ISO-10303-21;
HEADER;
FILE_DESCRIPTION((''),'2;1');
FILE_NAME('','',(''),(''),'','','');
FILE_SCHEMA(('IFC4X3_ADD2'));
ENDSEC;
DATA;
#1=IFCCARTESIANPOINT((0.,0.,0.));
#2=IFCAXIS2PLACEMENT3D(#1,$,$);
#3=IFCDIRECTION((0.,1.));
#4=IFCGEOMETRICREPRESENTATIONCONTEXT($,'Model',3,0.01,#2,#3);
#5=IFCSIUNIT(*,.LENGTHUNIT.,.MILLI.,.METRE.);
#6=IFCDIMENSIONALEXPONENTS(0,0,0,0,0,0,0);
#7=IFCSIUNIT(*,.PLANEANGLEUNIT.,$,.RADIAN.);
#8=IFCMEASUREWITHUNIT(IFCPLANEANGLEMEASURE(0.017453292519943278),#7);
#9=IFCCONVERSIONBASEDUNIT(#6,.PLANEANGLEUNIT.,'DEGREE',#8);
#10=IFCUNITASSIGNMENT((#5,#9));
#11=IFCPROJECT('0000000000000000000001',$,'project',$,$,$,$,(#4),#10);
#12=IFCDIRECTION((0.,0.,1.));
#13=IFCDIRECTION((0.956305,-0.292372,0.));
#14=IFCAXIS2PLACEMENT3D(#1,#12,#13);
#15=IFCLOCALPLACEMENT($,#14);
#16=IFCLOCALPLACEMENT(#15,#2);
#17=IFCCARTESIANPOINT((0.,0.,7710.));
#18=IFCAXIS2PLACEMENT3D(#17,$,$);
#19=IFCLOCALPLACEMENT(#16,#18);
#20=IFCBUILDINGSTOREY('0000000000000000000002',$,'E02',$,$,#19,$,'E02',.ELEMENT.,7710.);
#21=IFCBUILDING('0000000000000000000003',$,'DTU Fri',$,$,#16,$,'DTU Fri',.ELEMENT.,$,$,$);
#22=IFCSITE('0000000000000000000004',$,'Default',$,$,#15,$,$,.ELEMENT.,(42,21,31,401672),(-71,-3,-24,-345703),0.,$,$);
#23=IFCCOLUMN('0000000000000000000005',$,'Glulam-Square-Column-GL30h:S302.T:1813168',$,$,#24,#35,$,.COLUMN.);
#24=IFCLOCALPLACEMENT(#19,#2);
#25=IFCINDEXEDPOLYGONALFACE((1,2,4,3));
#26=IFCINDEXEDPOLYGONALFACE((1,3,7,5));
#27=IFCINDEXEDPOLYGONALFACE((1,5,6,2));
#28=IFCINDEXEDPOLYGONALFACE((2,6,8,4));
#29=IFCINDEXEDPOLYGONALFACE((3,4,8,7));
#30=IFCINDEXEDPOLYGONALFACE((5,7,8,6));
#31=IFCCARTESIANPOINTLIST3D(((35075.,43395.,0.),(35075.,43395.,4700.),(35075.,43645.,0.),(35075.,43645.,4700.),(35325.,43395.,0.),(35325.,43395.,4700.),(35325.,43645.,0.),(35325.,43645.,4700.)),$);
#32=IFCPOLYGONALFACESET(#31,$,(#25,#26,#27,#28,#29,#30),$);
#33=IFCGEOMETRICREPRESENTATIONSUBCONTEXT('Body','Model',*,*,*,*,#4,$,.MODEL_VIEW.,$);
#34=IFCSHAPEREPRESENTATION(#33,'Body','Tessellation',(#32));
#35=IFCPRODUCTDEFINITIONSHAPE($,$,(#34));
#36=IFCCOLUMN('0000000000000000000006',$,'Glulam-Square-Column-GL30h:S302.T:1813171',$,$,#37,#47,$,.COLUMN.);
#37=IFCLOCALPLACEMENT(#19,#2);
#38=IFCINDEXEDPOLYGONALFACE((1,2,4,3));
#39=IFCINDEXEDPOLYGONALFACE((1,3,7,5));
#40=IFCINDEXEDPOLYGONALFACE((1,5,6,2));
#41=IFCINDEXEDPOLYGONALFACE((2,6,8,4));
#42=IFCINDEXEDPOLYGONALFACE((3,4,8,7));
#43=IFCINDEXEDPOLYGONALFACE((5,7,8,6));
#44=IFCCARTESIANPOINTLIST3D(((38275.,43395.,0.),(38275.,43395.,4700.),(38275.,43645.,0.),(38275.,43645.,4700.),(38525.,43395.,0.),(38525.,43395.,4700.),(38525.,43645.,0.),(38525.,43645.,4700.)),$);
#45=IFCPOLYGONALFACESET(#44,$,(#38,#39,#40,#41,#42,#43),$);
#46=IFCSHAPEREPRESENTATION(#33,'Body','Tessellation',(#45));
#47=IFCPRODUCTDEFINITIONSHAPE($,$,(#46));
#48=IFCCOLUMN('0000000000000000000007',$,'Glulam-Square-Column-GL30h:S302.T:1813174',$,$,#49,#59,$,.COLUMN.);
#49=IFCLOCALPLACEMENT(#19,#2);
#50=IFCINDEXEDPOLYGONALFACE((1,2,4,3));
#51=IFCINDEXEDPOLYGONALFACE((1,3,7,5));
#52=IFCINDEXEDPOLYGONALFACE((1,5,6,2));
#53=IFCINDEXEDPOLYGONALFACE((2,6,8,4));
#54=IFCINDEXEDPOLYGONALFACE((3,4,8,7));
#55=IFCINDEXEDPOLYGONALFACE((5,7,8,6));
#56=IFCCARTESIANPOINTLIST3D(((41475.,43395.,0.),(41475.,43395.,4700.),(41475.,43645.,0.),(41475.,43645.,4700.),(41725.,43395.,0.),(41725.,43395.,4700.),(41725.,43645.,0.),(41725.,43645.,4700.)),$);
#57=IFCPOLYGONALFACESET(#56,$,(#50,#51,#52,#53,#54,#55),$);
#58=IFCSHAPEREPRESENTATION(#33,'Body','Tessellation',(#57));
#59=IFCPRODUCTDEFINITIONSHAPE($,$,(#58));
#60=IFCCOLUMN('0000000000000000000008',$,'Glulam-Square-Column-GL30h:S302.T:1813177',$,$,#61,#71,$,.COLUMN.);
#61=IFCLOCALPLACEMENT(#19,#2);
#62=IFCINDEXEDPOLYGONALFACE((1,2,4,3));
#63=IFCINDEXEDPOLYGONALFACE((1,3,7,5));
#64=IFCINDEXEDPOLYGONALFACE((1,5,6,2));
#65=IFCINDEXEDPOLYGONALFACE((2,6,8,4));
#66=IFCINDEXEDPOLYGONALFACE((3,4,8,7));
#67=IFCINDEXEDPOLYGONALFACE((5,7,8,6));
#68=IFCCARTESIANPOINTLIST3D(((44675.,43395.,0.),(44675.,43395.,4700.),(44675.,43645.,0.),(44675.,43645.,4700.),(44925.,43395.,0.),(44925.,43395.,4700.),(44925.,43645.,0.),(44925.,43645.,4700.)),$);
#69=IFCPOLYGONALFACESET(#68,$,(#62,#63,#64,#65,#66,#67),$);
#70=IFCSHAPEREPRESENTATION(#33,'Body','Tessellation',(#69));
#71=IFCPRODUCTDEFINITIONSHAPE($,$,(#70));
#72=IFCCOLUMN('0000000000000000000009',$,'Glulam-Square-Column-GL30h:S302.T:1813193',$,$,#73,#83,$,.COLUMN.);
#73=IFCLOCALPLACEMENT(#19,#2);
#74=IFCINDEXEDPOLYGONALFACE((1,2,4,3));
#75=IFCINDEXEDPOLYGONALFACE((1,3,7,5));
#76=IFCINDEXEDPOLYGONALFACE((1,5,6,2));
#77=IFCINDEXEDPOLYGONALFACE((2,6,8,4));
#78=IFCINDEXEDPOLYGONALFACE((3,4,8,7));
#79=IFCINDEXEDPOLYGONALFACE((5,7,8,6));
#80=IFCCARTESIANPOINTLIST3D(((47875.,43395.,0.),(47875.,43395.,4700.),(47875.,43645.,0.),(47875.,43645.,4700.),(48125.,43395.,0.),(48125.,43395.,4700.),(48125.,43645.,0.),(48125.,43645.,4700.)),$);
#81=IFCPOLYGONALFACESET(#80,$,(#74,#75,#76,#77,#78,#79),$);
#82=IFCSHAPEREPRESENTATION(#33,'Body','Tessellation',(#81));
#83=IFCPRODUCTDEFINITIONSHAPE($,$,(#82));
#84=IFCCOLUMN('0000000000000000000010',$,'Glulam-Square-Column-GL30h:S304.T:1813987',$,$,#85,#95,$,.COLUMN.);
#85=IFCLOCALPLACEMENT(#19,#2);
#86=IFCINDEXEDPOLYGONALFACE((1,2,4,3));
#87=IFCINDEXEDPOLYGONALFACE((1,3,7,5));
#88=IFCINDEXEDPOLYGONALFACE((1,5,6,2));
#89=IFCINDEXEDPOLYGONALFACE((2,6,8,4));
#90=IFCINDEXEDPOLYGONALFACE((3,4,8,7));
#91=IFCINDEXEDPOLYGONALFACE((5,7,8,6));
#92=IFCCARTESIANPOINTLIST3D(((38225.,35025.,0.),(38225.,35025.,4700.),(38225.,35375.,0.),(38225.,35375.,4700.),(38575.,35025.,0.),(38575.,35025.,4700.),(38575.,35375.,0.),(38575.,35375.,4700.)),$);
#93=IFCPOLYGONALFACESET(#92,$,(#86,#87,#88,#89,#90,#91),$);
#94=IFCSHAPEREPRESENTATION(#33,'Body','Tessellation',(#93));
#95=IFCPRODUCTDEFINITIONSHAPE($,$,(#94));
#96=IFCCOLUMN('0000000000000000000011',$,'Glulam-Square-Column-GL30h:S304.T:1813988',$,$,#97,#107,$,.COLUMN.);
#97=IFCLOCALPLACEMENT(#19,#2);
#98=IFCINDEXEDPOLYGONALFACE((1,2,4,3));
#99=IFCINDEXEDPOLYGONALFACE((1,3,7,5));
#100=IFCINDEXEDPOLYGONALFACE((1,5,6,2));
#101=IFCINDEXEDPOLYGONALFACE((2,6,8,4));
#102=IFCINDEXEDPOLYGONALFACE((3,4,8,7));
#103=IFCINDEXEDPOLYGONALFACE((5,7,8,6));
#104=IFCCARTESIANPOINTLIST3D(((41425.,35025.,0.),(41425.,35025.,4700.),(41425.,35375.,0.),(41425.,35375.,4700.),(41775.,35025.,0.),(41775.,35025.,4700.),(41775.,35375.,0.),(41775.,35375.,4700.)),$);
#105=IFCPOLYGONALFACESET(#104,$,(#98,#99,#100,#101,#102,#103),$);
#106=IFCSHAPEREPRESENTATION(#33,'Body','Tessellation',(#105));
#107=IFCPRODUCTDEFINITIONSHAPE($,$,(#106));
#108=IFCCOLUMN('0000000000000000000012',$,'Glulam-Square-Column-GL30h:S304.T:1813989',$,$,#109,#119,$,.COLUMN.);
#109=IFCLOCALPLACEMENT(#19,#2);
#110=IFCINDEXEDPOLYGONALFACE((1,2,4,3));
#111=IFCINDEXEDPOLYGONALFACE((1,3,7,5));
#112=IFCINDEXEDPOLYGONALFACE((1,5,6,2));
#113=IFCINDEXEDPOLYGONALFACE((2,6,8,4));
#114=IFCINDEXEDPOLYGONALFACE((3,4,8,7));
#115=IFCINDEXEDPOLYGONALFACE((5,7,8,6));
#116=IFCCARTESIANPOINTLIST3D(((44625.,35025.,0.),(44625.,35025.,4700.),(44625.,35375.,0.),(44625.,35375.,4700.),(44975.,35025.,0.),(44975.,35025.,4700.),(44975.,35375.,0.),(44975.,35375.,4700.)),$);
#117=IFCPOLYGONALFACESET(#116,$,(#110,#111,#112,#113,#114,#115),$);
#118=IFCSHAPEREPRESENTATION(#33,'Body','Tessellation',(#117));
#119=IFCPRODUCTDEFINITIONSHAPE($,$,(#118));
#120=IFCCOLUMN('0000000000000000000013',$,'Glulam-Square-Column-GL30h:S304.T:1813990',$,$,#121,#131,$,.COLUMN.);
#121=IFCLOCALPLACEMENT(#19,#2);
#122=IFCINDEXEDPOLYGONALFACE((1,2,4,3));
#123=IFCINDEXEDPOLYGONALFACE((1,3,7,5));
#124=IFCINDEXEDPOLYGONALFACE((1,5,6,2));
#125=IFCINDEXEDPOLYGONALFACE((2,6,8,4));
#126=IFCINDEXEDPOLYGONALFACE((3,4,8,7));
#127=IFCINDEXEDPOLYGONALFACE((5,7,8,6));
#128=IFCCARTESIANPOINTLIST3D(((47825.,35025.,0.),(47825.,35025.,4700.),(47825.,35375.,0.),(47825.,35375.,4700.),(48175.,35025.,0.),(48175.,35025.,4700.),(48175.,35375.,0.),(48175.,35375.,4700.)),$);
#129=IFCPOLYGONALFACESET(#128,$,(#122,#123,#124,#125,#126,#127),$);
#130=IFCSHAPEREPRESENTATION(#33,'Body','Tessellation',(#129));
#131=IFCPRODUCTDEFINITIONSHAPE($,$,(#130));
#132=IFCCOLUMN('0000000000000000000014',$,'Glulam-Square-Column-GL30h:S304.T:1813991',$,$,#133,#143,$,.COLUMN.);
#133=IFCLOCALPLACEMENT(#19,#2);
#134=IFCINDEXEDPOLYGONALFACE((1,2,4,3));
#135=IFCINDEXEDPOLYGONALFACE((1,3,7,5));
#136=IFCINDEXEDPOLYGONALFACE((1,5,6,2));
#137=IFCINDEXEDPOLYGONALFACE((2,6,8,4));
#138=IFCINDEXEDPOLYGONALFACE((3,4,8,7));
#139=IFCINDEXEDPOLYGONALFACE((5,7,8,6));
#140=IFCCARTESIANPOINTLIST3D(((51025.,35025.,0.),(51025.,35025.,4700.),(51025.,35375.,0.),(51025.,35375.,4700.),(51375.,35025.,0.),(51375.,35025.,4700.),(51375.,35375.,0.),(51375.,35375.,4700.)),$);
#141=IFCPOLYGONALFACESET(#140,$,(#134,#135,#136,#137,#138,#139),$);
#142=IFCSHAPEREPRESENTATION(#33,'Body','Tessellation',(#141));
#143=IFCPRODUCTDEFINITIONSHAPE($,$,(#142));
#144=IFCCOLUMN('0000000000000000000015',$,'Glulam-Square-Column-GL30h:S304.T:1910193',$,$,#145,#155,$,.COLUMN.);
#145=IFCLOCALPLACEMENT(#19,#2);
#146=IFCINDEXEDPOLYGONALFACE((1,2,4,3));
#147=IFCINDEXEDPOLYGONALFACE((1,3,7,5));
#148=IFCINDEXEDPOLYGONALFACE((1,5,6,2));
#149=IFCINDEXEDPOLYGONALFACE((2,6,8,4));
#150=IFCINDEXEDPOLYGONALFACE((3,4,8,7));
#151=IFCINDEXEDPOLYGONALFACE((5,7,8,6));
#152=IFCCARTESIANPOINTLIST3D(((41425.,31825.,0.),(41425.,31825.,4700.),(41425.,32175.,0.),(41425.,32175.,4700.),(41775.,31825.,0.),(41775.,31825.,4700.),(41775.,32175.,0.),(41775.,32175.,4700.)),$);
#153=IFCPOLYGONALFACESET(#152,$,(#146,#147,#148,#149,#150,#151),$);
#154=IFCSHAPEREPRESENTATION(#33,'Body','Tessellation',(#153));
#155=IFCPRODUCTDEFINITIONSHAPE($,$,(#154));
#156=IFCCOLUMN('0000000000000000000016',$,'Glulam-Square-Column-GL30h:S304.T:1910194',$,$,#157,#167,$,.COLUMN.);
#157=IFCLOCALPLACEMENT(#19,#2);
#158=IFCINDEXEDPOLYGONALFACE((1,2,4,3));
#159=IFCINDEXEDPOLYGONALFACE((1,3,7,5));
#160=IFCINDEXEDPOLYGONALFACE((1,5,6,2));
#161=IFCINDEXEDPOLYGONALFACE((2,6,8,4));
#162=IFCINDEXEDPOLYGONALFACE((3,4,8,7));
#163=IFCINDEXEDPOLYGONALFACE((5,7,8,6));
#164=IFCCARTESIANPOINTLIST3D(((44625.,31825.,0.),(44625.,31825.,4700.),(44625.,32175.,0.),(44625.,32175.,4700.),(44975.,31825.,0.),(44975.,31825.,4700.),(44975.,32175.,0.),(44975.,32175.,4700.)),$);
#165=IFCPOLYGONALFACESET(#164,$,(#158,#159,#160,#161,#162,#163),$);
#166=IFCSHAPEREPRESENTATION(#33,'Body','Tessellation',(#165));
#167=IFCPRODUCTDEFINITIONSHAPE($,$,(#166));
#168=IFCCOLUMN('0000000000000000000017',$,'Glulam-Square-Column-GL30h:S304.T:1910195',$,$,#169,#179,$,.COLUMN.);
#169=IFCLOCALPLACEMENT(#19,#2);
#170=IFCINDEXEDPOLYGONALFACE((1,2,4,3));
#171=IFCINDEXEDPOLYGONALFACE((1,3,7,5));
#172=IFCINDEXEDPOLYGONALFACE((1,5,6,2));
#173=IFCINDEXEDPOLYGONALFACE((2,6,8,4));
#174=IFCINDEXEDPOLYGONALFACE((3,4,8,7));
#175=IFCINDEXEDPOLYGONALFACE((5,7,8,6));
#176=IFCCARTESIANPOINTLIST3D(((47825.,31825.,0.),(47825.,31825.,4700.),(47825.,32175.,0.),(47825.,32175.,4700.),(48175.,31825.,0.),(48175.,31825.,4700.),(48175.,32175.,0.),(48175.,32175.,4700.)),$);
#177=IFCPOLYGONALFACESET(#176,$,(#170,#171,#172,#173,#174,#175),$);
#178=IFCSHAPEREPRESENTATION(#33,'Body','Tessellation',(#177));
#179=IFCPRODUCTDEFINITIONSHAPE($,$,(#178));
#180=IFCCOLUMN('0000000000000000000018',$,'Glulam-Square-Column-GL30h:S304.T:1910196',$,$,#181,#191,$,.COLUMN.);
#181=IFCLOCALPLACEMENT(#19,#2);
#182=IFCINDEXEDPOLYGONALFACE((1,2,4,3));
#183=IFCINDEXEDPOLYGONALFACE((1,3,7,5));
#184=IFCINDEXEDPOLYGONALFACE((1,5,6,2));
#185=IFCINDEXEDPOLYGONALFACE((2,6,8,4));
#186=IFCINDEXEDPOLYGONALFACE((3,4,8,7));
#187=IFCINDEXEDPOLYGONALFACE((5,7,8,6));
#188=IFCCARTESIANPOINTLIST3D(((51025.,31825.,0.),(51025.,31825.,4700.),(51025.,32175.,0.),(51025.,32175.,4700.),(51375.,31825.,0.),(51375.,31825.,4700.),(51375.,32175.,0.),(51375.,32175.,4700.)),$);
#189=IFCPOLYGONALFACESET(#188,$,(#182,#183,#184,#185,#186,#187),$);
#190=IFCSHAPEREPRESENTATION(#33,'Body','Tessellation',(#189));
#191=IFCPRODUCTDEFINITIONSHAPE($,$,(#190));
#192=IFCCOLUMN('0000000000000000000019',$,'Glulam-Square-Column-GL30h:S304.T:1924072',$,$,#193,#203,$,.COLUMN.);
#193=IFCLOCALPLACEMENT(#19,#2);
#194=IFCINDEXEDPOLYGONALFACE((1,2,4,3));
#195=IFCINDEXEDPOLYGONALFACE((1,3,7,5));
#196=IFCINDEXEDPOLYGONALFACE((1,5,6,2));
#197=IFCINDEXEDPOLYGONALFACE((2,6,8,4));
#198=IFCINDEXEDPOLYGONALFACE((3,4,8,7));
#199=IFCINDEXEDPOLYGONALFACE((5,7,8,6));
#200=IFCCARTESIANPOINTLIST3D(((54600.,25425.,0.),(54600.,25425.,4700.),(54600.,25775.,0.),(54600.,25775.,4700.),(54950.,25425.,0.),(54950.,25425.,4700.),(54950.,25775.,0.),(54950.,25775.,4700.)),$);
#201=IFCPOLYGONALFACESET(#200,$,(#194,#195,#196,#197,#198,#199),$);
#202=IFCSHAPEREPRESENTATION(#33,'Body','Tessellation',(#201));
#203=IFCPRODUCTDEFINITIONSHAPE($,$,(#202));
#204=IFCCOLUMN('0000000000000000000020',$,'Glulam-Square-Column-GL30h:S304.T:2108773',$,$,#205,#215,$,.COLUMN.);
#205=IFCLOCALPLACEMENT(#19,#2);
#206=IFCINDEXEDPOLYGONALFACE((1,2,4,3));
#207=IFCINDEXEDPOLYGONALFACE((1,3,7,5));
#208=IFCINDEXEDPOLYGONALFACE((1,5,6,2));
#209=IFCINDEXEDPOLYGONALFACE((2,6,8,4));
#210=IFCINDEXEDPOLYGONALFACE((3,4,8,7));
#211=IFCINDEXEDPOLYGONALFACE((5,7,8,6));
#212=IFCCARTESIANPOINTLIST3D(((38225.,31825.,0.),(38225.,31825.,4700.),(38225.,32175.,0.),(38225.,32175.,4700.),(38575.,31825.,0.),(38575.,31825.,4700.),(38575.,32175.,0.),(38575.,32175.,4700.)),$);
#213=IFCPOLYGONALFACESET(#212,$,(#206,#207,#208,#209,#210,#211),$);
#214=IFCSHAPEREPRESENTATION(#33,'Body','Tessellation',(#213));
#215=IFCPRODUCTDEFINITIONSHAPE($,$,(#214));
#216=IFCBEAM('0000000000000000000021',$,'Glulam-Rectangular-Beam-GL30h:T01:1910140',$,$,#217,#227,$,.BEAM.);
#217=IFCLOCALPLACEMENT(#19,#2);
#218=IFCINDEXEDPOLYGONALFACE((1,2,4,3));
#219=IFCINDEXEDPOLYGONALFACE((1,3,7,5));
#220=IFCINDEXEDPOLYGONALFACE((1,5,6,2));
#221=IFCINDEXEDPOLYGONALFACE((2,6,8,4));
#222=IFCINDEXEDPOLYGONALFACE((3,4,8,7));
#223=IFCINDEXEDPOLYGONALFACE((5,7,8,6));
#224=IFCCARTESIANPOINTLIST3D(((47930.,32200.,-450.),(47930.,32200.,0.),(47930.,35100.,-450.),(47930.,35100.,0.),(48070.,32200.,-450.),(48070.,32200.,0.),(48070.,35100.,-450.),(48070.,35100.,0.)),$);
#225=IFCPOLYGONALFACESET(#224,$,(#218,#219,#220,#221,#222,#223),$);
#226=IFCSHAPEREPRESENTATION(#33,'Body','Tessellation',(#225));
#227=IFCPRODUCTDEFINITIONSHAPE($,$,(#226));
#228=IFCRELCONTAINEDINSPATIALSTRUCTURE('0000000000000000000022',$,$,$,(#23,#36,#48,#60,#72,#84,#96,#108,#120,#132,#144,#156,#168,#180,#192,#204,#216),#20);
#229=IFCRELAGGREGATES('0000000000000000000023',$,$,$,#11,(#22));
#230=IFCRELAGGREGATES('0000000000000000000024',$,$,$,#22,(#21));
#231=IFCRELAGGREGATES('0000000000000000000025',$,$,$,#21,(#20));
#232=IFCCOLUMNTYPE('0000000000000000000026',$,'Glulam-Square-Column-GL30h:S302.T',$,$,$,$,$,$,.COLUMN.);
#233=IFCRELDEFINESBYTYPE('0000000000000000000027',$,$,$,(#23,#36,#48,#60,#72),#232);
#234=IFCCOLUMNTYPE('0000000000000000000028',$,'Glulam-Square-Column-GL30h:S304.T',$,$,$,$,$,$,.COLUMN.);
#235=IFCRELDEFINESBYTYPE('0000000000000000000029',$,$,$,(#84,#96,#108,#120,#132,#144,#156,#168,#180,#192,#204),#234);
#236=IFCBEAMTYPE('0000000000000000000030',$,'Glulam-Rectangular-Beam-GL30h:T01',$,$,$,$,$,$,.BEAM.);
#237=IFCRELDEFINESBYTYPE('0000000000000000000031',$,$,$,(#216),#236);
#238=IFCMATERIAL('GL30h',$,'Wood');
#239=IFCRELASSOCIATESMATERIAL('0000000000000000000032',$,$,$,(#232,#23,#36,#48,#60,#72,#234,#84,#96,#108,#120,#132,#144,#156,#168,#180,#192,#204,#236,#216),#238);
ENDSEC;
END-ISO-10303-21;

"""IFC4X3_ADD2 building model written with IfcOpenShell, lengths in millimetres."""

from ifc_helpers import new_model, entity, si_unit, converted_unit, direction, frame, origin, origin_2d_with_axis, place, context, subcontext, project, spatial, rectangle, extrude, source, transform, mapped, material, material_profile, profile_set, profile_usage, type_object, type_shapes, element, save


model = new_model("IFC4X3_ADD2")

# Units and contexts
model_context = context("Model", 3, precision=0.01, world=origin(), true_north=direction((0.0, 1.0)))
body_context = subcontext(model_context, "Body", "Model", "MODEL_VIEW")
ifc_project = project(units=[si_unit("LENGTHUNIT", "METRE", prefix="MILLI"), converted_unit("PLANEANGLEUNIT", "DEGREE", entity("IfcPlaneAngleMeasure", 0.017453292519943278), si_unit("PLANEANGLEUNIT", "RADIAN"), dimensions=[0, 0, 0, 0, 0, 0, 0])], contexts=[model_context])

# Site, building, storey
site_placement = place(None, frame((0.0, 0.0, 0.0), z_axis=(0.0, 0.0, 1.0), x_axis=(0.956305, -0.292372, 0.0)))
site = spatial("IfcSite", under=ifc_project, at=site_placement, Name="Default", CompositionType="ELEMENT", RefLatitude=(42, 21, 31, 401672), RefLongitude=(-71, -3, -24, -345703), RefElevation=0.0)
building_placement = place(site_placement, origin())
building = spatial("IfcBuilding", under=site, at=building_placement, Name="DTU Fri", LongName="DTU Fri", CompositionType="ELEMENT")
storey_placement = place(building_placement, frame((0.0, 0.0, 7710.0)))
storey = spatial("IfcBuildingStorey", under=building, at=storey_placement, Name="E02", LongName="E02", CompositionType="ELEMENT", Elevation=7710.0)

# Columns
ifc_material_1 = material(Name="GL30h", Category="Wood")
ifc_material_profile_1 = material_profile(ifc_material_1, rectangle(XDim=250.0, YDim=250.0, at=origin_2d_with_axis()), Name="S302.T")
ifc_profile_set_1 = profile_set([ifc_material_profile_1], Name="S302.T")
ifc_profile_usage_1 = profile_usage(ifc_profile_set_1)
column_type_1 = type_object("IfcColumnType", Name="Glulam-Square-Column-GL30h:S302.T", PredefinedType="COLUMN", material=ifc_profile_set_1)
shared_shape_1 = source(origin(), body_context, "Body", "SweptSolid", [
    extrude(rectangle(XDim=250.0, YDim=250.0, at=origin_2d_with_axis()), frame((0.0, 0.0, 7710.0), z_axis=(0.0, 0.0, 1.0), x_axis=(0.0, 1.0, 0.0)), (0.0, 0.0, 1.0), 4700.0),
])
type_shapes(column_type_1, [shared_shape_1])
for number, where, name in (
    (1, (35200.0, 43520.0, -7710.0), "Glulam-Square-Column-GL30h:S302.T:1813168"),
    (2, (38400.0, 43520.0, -7710.0), "Glulam-Square-Column-GL30h:S302.T:1813171"),
    (3, (41600.0, 43520.0, -7710.0), "Glulam-Square-Column-GL30h:S302.T:1813174"),
    (4, (44800.0, 43520.0, -7710.0), "Glulam-Square-Column-GL30h:S302.T:1813177"),
    (5, (48000.0, 43520.0, -7710.0), "Glulam-Square-Column-GL30h:S302.T:1813193"),
):
    element("IfcColumn", number, at=place(storey_placement, frame(where)), inside=storey, type_object=column_type_1, material=ifc_profile_usage_1, Name=name, PredefinedType="COLUMN", context=body_context, shape_type="MappedRepresentation", body=[
        mapped(shared_shape_1, transform((0.0, 0.0, 0.0), scale=1.0)),
    ])
ifc_material_profile_2 = material_profile(ifc_material_1, rectangle(XDim=350.0, YDim=350.0, at=origin_2d_with_axis()), Name="S304.T")
ifc_profile_set_2 = profile_set([ifc_material_profile_2], Name="S304.T")
ifc_profile_usage_2 = profile_usage(ifc_profile_set_2)
column_type_2 = type_object("IfcColumnType", Name="Glulam-Square-Column-GL30h:S304.T", PredefinedType="COLUMN", material=ifc_profile_set_2)
shared_shape_2 = source(origin(), body_context, "Body", "SweptSolid", [
    extrude(rectangle(XDim=350.0, YDim=350.0, at=origin_2d_with_axis()), frame((0.0, 0.0, 7710.0), z_axis=(0.0, 0.0, 1.0), x_axis=(0.0, 1.0, 0.0)), (0.0, 0.0, 1.0), 4700.0),
])
type_shapes(column_type_2, [shared_shape_2])
for number, where, name in (
    (6, (38400.0, 35200.0, -7710.0), "Glulam-Square-Column-GL30h:S304.T:1813987"),
    (7, (41600.0, 35200.0, -7710.0), "Glulam-Square-Column-GL30h:S304.T:1813988"),
    (8, (44800.0, 35200.0, -7710.0), "Glulam-Square-Column-GL30h:S304.T:1813989"),
    (9, (48000.0, 35200.0, -7710.0), "Glulam-Square-Column-GL30h:S304.T:1813990"),
    (10, (51200.0, 35200.0, -7710.0), "Glulam-Square-Column-GL30h:S304.T:1813991"),
    (11, (41600.0, 32000.0, -7710.0), "Glulam-Square-Column-GL30h:S304.T:1910193"),
    (12, (44800.0, 32000.0, -7710.0), "Glulam-Square-Column-GL30h:S304.T:1910194"),
    (13, (48000.0, 32000.0, -7710.0), "Glulam-Square-Column-GL30h:S304.T:1910195"),
    (14, (51200.0, 32000.0, -7710.0), "Glulam-Square-Column-GL30h:S304.T:1910196"),
    (15, (54775.0, 25600.0, -7710.0), "Glulam-Square-Column-GL30h:S304.T:1924072"),
    (16, (38400.0, 32000.0, -7710.0), "Glulam-Square-Column-GL30h:S304.T:2108773"),
):
    element("IfcColumn", number, at=place(storey_placement, frame(where)), inside=storey, type_object=column_type_2, material=ifc_profile_usage_2, Name=name, PredefinedType="COLUMN", context=body_context, shape_type="MappedRepresentation", body=[
        mapped(shared_shape_2, transform((0.0, 0.0, 0.0), scale=1.0)),
    ])

# Beam
ifc_material_profile_3 = material_profile(ifc_material_1, rectangle(XDim=450.0, YDim=140.0, at=origin_2d_with_axis()), Name="T01")
ifc_profile_set_3 = profile_set([ifc_material_profile_3], Name="T01")
ifc_profile_usage_3 = profile_usage(ifc_profile_set_3, cardinal=8)
beam_type_1 = type_object("IfcBeamType", Name="Glulam-Rectangular-Beam-GL30h:T01", PredefinedType="BEAM", material=ifc_profile_set_3)
shared_shape_3 = source(origin(), body_context, "Body", "SweptSolid", [
    extrude(rectangle(XDim=450.0, YDim=140.0, at=origin_2d_with_axis()), frame((-1400.0, 0.0, 0.0), z_axis=(1.0, 0.0, 0.0), x_axis=(0.0, 0.0, -1.0)), (0.0, 0.0, 1.0), 2900.0),
])
type_shapes(beam_type_1, [shared_shape_3])
beam_1_placement = place(storey_placement, frame((48000.0, 33600.0, -225.0), z_axis=(0.0, 0.0, 1.0), x_axis=(0.0, 1.0, 0.0)))
element("IfcBeam", 17, at=beam_1_placement, inside=storey, type_object=beam_type_1, material=ifc_profile_usage_3, Name="Glulam-Rectangular-Beam-GL30h:T01:1910140", PredefinedType="BEAM", context=body_context, shape_type="MappedRepresentation", body=[
    mapped(shared_shape_3, transform((0.0, 0.0, 0.0), scale=1.0)),
])

save(model, "model.ifc")
